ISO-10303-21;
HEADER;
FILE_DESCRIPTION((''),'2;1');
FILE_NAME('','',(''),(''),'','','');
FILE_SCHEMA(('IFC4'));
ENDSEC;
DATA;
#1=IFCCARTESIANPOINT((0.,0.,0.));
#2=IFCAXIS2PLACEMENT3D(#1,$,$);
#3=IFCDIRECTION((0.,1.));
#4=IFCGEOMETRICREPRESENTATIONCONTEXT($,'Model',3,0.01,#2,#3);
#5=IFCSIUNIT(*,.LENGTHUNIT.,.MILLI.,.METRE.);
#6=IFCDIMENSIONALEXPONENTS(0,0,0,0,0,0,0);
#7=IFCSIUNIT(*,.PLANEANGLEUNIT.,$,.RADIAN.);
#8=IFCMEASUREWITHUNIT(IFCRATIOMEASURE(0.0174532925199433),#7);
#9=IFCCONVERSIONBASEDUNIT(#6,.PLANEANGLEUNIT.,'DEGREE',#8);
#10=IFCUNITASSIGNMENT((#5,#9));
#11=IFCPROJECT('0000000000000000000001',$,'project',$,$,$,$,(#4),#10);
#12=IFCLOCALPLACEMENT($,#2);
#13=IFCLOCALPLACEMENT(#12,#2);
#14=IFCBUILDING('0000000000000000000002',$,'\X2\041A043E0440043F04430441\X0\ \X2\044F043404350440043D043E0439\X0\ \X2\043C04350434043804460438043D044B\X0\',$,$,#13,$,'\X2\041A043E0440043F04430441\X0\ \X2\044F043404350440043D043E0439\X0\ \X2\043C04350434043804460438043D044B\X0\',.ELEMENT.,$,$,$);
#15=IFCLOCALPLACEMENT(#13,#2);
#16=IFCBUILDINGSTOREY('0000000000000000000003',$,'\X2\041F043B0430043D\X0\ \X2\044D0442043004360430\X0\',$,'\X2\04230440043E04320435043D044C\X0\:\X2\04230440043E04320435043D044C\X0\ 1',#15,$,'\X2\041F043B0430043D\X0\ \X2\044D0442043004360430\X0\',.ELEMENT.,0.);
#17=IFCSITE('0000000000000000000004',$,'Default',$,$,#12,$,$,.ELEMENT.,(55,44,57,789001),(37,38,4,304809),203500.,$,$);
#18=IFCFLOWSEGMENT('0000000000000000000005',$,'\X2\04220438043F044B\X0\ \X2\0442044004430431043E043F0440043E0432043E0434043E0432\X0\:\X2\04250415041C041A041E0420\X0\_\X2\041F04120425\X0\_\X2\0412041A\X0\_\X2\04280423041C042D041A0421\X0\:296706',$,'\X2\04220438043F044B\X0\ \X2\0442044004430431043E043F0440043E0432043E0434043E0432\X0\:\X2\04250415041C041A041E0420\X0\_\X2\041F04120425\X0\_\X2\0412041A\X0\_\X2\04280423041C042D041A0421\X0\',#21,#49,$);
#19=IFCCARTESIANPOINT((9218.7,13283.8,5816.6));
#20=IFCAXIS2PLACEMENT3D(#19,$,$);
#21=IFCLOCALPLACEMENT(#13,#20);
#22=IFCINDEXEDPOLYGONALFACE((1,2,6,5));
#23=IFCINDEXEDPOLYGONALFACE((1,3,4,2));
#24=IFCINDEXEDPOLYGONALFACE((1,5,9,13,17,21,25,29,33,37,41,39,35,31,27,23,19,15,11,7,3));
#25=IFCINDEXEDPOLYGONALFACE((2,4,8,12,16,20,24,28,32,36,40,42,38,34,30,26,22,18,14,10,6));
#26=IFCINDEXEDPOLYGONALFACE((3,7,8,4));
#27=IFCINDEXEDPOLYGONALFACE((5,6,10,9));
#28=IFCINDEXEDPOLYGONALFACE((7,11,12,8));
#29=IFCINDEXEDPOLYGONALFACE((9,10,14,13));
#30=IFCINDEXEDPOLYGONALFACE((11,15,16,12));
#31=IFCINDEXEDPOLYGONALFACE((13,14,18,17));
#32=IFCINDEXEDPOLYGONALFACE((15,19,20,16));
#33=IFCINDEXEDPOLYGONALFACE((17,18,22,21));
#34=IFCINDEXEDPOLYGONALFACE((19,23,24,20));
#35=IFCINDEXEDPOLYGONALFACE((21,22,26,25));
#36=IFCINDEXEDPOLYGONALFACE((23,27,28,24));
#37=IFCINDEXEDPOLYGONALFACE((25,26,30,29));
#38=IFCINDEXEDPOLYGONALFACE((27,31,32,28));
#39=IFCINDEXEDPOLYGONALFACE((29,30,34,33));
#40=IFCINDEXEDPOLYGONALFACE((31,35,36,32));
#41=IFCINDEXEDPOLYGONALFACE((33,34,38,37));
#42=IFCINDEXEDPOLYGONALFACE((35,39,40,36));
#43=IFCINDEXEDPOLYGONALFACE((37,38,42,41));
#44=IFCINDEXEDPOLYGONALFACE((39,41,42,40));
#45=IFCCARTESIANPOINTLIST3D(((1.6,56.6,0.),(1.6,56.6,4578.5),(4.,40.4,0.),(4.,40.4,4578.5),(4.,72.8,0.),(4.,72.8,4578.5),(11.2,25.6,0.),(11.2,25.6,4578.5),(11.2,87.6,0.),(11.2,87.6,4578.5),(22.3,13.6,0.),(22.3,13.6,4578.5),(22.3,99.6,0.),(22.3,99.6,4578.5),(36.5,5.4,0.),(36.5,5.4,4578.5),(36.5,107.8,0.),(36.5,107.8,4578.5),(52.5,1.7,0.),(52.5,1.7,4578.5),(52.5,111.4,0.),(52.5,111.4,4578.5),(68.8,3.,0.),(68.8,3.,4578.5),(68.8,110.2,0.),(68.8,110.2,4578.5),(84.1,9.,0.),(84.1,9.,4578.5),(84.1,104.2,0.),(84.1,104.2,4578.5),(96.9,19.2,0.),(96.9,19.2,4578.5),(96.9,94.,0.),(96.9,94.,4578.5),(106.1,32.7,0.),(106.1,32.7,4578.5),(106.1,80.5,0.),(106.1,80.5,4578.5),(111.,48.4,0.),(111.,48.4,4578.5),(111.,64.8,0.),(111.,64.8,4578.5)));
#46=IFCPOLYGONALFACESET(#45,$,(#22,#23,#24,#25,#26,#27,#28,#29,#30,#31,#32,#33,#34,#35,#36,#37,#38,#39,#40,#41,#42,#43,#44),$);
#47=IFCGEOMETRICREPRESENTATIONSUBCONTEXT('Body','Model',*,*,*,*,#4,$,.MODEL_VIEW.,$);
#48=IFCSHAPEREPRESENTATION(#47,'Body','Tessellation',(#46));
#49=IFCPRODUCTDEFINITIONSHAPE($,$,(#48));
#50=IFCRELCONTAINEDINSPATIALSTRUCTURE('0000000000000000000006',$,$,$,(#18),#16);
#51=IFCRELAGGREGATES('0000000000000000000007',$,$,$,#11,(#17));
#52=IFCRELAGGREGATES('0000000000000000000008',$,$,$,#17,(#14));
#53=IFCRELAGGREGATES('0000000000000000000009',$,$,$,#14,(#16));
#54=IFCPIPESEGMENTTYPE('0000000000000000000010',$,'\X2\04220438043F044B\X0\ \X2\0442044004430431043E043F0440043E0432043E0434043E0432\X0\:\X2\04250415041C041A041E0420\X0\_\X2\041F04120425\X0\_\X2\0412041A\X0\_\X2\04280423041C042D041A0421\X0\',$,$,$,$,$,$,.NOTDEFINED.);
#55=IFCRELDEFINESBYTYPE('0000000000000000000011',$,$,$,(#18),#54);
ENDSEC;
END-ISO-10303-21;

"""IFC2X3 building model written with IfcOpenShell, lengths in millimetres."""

from ifc_helpers import new_model, entity, si_unit, converted_unit, direction, frame, origin, origin_2d_with_axis, place, context, subcontext, project, spatial, circle, extrude, type_object, element, save


model = new_model("IFC2X3")

# Units and contexts
model_context = context("Model", 3, precision=0.01, world=origin(), true_north=direction((0.0, 1.0)))
body_context = subcontext(model_context, "Body", "Model", "MODEL_VIEW")
ifc_project = project(units=[si_unit("LENGTHUNIT", "METRE", prefix="MILLI"), converted_unit("PLANEANGLEUNIT", "DEGREE", entity("IfcRatioMeasure", 0.0174532925199433), si_unit("PLANEANGLEUNIT", "RADIAN"), dimensions=[0, 0, 0, 0, 0, 0, 0])], contexts=[model_context])

# Site, building, storey
site_placement = place(None, frame((0.0, 0.0, 0.0)))
site = spatial("IfcSite", under=ifc_project, at=site_placement, Name="Default", CompositionType="ELEMENT", RefLatitude=(55, 44, 57, 789001), RefLongitude=(37, 38, 4, 304809), RefElevation=203500.0)
building_placement = place(site_placement, origin())
building = spatial("IfcBuilding", under=site, at=building_placement, Name="Корпус ядерной медицины", LongName="Корпус ядерной медицины", CompositionType="ELEMENT")
storey_placement = place(building_placement, origin())
storey = spatial("IfcBuildingStorey", under=building, at=storey_placement, Name="План этажа", ObjectType="Уровень:Уровень 1", LongName="План этажа", CompositionType="ELEMENT", Elevation=0.0)

# Flow segment
pipe_segment_type = type_object("IfcPipeSegmentType", Name="Типы трубопроводов:ХЕМКОР_ПВХ_ВК_ШУМЭКС", PredefinedType="NOTDEFINED")
flow_segment_placement = place(building_placement, frame((9218.7, 13283.8, 5816.6)))
element("IfcFlowSegment", 1, at=flow_segment_placement, inside=storey, type_object=pipe_segment_type, Name="Типы трубопроводов:ХЕМКОР_ПВХ_ВК_ШУМЭКС:296706", ObjectType="Типы трубопроводов:ХЕМКОР_ПВХ_ВК_ШУМЭКС", context=body_context, shape_type="SweptSolid", body=[
    extrude(circle(Radius=55.0, at=origin_2d_with_axis()), frame((56.6, 56.6, 0.0), z_axis=(0.0, 0.0, 1.0), x_axis=(-1.0, 0.0, 0.0)), (0.0, 0.0, 1.0), 4578.5),
])

save(model, "model.ifc")
